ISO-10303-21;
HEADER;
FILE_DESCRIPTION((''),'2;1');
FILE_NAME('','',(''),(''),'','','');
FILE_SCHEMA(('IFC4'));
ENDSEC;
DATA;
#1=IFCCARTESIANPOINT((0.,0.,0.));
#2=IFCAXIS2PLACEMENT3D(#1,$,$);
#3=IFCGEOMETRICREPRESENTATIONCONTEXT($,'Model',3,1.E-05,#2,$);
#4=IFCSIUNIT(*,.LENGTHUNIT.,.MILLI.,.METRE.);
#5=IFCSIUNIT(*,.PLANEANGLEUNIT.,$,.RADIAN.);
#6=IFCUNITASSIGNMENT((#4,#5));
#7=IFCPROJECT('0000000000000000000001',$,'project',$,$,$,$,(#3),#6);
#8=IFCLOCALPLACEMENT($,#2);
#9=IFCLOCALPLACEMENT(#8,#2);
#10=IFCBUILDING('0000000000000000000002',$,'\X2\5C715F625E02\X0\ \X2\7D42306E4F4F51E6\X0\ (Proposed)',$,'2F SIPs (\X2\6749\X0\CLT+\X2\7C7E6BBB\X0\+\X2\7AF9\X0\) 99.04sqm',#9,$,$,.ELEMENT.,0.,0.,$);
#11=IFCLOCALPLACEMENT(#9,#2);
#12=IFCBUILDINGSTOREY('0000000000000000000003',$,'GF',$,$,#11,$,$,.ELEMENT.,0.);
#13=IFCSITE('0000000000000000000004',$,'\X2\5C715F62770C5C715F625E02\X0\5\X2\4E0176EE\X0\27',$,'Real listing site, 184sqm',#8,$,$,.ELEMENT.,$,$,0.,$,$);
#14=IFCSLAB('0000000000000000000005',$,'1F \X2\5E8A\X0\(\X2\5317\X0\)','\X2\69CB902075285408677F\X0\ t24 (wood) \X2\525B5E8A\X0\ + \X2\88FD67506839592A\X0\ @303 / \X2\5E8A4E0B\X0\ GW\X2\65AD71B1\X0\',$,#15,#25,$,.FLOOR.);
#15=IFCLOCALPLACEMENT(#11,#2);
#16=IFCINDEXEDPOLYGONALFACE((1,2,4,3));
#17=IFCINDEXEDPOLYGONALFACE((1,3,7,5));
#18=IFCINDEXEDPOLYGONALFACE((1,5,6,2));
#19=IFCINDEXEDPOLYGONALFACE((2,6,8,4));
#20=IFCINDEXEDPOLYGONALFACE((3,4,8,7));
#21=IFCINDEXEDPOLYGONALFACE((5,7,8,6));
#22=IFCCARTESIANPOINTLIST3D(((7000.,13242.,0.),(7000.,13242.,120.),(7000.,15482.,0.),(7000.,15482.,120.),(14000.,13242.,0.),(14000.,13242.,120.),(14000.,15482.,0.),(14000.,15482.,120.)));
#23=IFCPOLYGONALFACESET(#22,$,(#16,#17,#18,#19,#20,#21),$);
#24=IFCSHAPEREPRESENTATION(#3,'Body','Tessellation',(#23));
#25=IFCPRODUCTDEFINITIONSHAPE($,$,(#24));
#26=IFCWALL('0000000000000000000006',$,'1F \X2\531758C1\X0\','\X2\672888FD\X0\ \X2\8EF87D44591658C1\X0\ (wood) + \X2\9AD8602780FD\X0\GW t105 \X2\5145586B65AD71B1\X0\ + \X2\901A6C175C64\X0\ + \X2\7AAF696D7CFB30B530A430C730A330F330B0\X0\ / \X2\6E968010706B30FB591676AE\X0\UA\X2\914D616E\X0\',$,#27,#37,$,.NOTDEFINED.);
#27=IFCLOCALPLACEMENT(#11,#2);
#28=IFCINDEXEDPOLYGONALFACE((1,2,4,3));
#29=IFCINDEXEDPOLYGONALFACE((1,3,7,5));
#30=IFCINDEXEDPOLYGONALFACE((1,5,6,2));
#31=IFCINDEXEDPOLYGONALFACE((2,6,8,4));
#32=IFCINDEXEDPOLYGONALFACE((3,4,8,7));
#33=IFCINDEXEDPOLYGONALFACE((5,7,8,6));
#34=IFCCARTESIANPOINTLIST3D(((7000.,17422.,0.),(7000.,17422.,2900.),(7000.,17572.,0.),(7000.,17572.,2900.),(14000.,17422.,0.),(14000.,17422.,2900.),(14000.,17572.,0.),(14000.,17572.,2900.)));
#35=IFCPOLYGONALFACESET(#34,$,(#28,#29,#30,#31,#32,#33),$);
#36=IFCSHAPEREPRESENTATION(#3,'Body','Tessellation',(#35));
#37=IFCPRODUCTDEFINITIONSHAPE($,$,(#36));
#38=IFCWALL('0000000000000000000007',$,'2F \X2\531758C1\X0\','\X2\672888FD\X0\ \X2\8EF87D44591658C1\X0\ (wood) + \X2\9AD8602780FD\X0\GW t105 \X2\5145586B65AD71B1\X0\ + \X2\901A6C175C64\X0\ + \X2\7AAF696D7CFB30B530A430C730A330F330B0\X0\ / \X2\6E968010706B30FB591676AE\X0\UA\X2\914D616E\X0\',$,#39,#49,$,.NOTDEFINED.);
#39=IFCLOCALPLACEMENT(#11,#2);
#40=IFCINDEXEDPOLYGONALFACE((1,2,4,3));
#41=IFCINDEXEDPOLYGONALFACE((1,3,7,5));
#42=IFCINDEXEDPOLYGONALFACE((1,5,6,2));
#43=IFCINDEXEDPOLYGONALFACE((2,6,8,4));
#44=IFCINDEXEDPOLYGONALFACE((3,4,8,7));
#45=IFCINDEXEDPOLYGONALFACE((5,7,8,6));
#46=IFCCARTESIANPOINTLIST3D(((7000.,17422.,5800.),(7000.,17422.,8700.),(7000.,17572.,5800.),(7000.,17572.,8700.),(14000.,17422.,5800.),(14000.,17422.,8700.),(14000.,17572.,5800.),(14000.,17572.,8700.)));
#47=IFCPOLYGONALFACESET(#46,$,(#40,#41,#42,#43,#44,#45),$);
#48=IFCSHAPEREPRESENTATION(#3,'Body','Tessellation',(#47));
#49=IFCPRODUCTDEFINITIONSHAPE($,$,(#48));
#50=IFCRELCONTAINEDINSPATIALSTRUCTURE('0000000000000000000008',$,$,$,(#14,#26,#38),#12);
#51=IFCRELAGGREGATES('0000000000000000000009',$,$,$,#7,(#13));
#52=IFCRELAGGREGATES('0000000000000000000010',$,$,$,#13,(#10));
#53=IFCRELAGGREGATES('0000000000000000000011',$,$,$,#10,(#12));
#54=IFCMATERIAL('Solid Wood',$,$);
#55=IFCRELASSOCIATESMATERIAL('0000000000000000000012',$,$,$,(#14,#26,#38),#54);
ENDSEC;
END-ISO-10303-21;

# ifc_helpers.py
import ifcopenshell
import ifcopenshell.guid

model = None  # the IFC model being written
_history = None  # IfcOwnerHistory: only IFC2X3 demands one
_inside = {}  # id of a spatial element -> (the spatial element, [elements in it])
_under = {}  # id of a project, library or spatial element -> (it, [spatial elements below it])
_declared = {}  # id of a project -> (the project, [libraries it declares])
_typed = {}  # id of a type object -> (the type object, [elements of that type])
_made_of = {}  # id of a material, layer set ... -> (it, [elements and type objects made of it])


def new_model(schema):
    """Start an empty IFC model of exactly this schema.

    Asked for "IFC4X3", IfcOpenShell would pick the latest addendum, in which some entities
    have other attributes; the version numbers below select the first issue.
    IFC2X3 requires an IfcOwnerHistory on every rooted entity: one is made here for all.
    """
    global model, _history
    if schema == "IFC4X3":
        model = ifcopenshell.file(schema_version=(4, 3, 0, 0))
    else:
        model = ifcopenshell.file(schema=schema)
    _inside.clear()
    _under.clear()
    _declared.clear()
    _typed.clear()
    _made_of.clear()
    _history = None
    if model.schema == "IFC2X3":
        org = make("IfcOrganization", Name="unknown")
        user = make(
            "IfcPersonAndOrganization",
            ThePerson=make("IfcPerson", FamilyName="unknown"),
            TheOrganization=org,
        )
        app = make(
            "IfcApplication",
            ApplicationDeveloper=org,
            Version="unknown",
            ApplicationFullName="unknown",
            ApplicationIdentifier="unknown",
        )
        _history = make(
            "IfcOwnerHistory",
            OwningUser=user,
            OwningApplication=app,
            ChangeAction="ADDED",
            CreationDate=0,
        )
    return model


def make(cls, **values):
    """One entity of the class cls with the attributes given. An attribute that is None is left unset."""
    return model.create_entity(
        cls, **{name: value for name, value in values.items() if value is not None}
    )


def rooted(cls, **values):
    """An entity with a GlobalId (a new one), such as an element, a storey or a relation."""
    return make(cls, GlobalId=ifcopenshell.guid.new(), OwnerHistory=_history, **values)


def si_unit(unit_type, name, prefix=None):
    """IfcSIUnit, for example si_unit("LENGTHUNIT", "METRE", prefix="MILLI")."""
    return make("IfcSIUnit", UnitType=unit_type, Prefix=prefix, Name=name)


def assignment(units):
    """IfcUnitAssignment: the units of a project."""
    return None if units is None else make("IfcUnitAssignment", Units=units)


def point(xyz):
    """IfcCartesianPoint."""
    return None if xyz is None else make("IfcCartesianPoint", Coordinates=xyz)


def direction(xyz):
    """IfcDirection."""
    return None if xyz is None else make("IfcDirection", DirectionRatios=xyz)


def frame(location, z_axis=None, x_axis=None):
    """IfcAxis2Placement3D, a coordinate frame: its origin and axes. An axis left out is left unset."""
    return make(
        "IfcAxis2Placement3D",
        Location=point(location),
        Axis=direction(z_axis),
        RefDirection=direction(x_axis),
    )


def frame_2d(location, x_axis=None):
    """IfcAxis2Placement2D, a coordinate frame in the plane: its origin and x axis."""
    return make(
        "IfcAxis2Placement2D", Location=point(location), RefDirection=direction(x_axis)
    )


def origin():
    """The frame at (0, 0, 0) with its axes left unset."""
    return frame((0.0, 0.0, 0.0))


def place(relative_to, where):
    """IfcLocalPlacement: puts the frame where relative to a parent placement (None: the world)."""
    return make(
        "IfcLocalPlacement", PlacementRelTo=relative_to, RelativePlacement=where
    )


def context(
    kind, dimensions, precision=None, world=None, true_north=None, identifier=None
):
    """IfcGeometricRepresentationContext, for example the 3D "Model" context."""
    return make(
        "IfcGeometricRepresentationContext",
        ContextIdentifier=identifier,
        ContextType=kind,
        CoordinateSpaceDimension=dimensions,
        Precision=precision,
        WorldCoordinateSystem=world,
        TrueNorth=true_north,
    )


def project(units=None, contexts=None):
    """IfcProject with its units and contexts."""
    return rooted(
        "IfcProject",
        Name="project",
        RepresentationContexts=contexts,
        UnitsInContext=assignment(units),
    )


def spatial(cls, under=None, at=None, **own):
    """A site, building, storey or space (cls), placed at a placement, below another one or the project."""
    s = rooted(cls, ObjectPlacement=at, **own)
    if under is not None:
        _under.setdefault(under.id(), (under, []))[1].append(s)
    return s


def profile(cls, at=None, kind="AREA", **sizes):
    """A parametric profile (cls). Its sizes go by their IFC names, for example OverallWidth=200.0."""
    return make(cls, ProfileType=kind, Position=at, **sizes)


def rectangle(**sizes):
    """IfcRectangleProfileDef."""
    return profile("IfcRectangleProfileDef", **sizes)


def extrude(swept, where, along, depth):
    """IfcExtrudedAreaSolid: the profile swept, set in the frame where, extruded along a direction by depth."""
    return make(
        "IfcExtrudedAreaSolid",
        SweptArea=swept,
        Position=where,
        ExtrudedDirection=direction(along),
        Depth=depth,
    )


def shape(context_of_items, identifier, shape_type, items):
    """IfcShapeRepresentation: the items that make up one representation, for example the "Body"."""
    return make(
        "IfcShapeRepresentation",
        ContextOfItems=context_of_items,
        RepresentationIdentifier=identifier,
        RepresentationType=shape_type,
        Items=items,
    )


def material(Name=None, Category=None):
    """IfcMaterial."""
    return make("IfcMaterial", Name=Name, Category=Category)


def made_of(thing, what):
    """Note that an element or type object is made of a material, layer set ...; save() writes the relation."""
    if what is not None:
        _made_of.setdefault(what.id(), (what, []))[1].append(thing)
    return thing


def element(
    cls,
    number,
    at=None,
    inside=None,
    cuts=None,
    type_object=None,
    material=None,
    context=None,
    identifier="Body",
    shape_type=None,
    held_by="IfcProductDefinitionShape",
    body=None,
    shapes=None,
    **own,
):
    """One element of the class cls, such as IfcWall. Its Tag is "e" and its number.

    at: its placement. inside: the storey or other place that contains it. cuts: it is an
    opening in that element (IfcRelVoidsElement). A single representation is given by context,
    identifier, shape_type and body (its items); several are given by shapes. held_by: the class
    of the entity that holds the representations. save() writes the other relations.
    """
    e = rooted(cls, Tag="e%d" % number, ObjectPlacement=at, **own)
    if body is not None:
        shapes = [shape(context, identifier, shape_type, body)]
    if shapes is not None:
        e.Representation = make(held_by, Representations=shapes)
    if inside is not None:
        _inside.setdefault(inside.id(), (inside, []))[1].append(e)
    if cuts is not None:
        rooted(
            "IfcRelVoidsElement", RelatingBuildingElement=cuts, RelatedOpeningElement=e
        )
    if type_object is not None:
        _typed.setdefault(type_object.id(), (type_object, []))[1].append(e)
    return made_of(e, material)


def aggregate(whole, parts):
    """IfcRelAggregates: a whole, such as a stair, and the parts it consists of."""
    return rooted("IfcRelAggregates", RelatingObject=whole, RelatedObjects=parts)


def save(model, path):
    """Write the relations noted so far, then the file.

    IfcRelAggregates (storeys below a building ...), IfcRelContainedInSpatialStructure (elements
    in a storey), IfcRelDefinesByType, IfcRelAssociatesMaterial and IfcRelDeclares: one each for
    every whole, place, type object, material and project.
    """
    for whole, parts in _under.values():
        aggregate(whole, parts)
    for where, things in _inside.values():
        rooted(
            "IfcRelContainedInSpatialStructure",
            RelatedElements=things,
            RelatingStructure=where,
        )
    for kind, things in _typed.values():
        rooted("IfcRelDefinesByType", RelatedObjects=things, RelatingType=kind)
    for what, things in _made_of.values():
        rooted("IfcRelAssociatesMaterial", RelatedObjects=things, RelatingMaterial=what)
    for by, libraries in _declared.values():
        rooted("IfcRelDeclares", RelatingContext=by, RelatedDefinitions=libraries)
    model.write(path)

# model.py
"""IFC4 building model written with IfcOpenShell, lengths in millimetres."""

from ifc_helpers import new_model, si_unit, frame, frame_2d, origin, place, context, project, spatial, rectangle, extrude, material, element, save


model = new_model("IFC4")

# Units and contexts
model_context = context("Model", 3, precision=1e-05, world=origin())
ifc_project = project(units=[si_unit("LENGTHUNIT", "METRE", prefix="MILLI"), si_unit("PLANEANGLEUNIT", "RADIAN")], contexts=[model_context])

# Site, building, storey
site_placement = place(None, origin())
site = spatial("IfcSite", under=ifc_project, at=site_placement, Name="山形県山形市5丁目27", ObjectType="Real listing site, 184sqm", CompositionType="ELEMENT", RefElevation=0.0)
building_placement = place(site_placement, origin())
building = spatial("IfcBuilding", under=site, at=building_placement, Name="山形市 終の住処 (Proposed)", ObjectType="2F SIPs (杉CLT+籾殻+竹) 99.04sqm", CompositionType="ELEMENT", ElevationOfRefHeight=0.0, ElevationOfTerrain=0.0)
storey_placement = place(building_placement, origin())
storey = spatial("IfcBuildingStorey", under=building, at=storey_placement, Name="GF", CompositionType="ELEMENT", Elevation=0.0)

# Slab
ifc_material_1 = material(Name="Solid Wood")
slab_1_placement = place(storey_placement, frame((3500.0, 6621.0, 0.0)))
element("IfcSlab", 1, at=slab_1_placement, inside=storey, material=ifc_material_1, Name="1F 床(北)", Description="構造用合板 t24 (wood) 剛床 + 製材根太 @303 / 床下 GW断熱", PredefinedType="FLOOR", context=model_context, shape_type="SweptSolid", body=[
    extrude(rectangle(XDim=7000.0, YDim=2240.0, at=frame_2d((3500.0, 1120.0))), frame((3500.0, 6621.0, 0.0)), (0.0, 0.0, 1.0), 120.0),
])

# Wall
wall_1_placement = place(storey_placement, frame((3500.0, 8711.0, 0.0)))
element("IfcWall", 2, at=wall_1_placement, inside=storey, material=ifc_material_1, Name="1F 北壁", Description="木製 軸組外壁 (wood) + 高性能GW t105 充填断熱 + 通気層 + 窯業系サイディング / 準耐火・外皮UA配慮", PredefinedType="NOTDEFINED", context=model_context, shape_type="SweptSolid", body=[
    extrude(rectangle(XDim=7000.0, YDim=150.0, at=frame_2d((3500.0, 75.0))), frame((3500.0, 8711.0, 0.0)), (0.0, 0.0, 1.0), 2900.0),
])

# Wall
wall_2_placement = place(storey_placement, frame((3500.0, 8711.0, 2900.0)))
element("IfcWall", 3, at=wall_2_placement, inside=storey, material=ifc_material_1, Name="2F 北壁", Description="木製 軸組外壁 (wood) + 高性能GW t105 充填断熱 + 通気層 + 窯業系サイディング / 準耐火・外皮UA配慮", PredefinedType="NOTDEFINED", context=model_context, shape_type="SweptSolid", body=[
    extrude(rectangle(XDim=7000.0, YDim=150.0, at=frame_2d((3500.0, 75.0))), frame((3500.0, 8711.0, 2900.0)), (0.0, 0.0, 1.0), 2900.0),
])

save(model, "model.ifc")
